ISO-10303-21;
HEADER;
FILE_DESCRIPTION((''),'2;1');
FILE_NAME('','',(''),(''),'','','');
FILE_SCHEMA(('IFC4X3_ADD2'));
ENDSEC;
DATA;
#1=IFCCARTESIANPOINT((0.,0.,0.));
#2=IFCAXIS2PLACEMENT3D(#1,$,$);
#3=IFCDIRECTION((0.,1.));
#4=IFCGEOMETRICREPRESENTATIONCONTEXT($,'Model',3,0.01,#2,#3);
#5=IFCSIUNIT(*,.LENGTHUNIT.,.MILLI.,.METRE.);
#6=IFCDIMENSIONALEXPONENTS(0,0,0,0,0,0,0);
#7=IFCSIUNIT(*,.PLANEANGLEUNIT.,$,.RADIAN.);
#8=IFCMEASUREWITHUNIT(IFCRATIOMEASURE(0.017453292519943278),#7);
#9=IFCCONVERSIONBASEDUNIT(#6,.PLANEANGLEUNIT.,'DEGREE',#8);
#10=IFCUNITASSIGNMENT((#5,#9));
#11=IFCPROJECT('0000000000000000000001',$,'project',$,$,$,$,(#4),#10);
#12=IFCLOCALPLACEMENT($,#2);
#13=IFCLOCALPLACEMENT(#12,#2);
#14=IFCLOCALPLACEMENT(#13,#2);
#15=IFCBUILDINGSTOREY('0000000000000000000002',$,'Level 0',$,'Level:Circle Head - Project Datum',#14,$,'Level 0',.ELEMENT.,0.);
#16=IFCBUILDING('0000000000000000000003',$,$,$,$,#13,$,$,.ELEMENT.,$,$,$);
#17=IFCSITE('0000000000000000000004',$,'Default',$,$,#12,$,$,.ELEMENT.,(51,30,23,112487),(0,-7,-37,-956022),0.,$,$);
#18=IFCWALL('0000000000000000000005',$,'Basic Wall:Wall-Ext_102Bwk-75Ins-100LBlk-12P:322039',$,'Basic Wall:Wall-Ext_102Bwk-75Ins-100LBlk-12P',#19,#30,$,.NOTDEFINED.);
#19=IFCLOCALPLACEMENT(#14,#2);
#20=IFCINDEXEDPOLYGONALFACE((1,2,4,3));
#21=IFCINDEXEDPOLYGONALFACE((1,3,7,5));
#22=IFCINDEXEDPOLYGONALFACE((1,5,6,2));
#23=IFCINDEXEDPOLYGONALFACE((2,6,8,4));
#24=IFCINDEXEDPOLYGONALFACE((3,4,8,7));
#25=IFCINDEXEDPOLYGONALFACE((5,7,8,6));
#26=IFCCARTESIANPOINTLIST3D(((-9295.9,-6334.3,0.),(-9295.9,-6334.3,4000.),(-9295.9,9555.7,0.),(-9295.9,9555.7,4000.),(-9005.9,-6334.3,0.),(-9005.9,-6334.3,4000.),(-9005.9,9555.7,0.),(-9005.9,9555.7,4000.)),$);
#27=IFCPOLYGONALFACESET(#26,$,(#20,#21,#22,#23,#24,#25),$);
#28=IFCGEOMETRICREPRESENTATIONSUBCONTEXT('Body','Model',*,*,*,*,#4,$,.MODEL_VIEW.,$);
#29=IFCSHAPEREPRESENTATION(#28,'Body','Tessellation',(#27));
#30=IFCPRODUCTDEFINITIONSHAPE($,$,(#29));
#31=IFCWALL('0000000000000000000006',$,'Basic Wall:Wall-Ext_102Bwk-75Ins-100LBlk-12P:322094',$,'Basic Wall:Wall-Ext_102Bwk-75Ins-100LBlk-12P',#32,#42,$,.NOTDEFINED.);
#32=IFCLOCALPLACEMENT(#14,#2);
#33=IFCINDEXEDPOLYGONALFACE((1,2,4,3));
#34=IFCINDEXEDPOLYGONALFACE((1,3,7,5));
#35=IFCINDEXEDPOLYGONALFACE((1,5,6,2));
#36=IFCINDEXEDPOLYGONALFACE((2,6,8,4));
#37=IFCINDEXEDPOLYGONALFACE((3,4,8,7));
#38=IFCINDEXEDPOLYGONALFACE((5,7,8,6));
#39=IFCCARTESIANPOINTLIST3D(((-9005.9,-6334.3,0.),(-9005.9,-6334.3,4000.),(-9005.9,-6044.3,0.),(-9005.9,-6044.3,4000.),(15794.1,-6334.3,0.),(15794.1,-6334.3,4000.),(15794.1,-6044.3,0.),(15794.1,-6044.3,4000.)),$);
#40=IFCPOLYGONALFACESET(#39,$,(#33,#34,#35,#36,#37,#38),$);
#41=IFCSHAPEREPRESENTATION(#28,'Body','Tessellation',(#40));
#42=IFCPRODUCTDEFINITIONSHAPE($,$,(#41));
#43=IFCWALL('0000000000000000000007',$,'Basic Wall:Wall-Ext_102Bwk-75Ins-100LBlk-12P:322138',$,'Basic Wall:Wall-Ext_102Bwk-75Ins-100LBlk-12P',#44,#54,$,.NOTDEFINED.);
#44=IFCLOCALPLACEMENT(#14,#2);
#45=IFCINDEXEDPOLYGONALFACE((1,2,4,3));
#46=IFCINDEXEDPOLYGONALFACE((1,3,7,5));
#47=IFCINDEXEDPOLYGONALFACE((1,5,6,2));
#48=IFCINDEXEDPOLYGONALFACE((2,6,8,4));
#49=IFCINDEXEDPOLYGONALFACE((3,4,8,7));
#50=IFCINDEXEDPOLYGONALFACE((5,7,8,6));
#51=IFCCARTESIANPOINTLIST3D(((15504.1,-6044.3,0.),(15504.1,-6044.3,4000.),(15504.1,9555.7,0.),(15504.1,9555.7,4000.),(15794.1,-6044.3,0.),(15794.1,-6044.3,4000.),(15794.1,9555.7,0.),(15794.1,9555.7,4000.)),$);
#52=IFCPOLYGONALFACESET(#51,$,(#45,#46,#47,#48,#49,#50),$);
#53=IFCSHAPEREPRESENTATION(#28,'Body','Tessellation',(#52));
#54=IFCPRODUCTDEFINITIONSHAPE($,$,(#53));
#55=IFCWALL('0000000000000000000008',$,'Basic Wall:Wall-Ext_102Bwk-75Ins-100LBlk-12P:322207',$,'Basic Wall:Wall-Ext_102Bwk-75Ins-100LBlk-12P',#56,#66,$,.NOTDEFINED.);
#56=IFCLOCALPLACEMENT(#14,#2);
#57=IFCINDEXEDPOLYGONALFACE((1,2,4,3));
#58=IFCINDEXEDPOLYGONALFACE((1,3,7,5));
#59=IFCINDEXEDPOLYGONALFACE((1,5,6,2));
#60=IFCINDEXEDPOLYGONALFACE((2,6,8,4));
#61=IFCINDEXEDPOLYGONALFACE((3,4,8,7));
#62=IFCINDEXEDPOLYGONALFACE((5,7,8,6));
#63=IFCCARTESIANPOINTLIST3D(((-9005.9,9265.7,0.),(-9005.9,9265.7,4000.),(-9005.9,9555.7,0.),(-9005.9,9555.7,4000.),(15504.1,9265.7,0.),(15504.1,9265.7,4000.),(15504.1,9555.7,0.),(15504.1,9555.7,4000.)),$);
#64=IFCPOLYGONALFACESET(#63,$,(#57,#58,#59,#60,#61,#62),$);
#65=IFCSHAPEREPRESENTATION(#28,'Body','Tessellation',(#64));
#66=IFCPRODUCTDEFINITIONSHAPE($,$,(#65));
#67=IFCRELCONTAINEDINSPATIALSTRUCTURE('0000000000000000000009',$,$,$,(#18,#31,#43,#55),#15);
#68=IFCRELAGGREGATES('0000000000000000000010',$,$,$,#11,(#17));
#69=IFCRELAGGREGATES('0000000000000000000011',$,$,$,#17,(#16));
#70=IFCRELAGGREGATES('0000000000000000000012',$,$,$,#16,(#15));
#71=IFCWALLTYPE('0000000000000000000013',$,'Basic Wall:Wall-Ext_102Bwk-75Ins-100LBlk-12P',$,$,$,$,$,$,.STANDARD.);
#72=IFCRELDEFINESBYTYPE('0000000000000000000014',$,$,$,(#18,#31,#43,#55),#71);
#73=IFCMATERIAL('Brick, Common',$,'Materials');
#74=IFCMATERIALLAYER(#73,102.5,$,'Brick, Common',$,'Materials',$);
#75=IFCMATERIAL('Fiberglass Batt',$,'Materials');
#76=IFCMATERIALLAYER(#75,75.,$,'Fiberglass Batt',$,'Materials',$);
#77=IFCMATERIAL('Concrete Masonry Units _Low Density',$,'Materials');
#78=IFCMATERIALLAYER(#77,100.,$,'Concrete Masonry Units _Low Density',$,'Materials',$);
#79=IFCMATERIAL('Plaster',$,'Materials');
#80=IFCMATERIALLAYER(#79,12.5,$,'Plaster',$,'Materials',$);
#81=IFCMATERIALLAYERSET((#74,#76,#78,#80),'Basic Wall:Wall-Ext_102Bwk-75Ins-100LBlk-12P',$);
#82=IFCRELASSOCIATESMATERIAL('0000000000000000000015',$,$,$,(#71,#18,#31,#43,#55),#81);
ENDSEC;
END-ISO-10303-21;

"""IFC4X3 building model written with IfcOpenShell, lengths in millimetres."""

from ifc_helpers import new_model, entity, si_unit, converted_unit, direction, frame, frame_2d, origin, place, context, subcontext, project, spatial, rectangle, extrude, clip, halfspace, material, layer, layer_set, type_object, element, save


model = new_model("IFC4X3")

# Units and contexts
model_context = context("Model", 3, precision=0.01, world=origin(), true_north=direction((0.0, 1.0)))
body_context = subcontext(model_context, "Body", "Model", "MODEL_VIEW")
ifc_project = project(units=[si_unit("LENGTHUNIT", "METRE", prefix="MILLI"), converted_unit("PLANEANGLEUNIT", "DEGREE", entity("IfcRatioMeasure", 0.017453292519943278), si_unit("PLANEANGLEUNIT", "RADIAN"), dimensions=[0, 0, 0, 0, 0, 0, 0])], contexts=[model_context])

# Site, building, storey
site_placement = place(None, origin())
site = spatial("IfcSite", under=ifc_project, at=site_placement, Name="Default", CompositionType="ELEMENT", RefLatitude=(51, 30, 23, 112487), RefLongitude=(0, -7, -37, -956022), RefElevation=0.0)
building_placement = place(site_placement, origin())
building = spatial("IfcBuilding", under=site, at=building_placement, CompositionType="ELEMENT")
storey_placement = place(building_placement, origin())
storey = spatial("IfcBuildingStorey", under=building, at=storey_placement, Name="Level 0", ObjectType="Level:Circle Head - Project Datum", LongName="Level 0", CompositionType="ELEMENT", Elevation=0.0)

# Walls
ifc_material_1 = material(Name="Brick, Common", Category="Materials")
ifc_layer_1 = layer(ifc_material_1, 102.5, Name="Brick, Common", Category="Materials")
ifc_material_2 = material(Name="Fiberglass Batt", Category="Materials")
ifc_layer_2 = layer(ifc_material_2, 75.0, Name="Fiberglass Batt", Category="Materials")
ifc_material_3 = material(Name="Concrete Masonry Units _Low Density", Category="Materials")
ifc_layer_3 = layer(ifc_material_3, 100.0, Name="Concrete Masonry Units _Low Density", Category="Materials")
ifc_material_4 = material(Name="Plaster", Category="Materials")
ifc_layer_4 = layer(ifc_material_4, 12.5, Name="Plaster", Category="Materials")
ifc_layer_set = layer_set([ifc_layer_1, ifc_layer_2, ifc_layer_3, ifc_layer_4], Name="Basic Wall:Wall-Ext_102Bwk-75Ins-100LBlk-12P")
wall_type = type_object("IfcWallType", Name="Basic Wall:Wall-Ext_102Bwk-75Ins-100LBlk-12P", PredefinedType="STANDARD", material=ifc_layer_set)
wall_1_placement = place(storey_placement, frame((-9150.9, 9555.7, 0.0), z_axis=(0.0, 0.0, 1.0), x_axis=(0.0, -1.0, 0.0)))
element("IfcWall", 1, at=wall_1_placement, inside=storey, type_object=wall_type, material=ifc_layer_set, Name="Basic Wall:Wall-Ext_102Bwk-75Ins-100LBlk-12P:322039", ObjectType="Basic Wall:Wall-Ext_102Bwk-75Ins-100LBlk-12P", PredefinedType="NOTDEFINED", context=body_context, shape_type="Clipping", body=[
    clip(extrude(rectangle(XDim=15890.0, YDim=290.0, at=frame_2d((7945.0, 0.0), x_axis=(-1.0, 0.0))), origin(), (0.0, 0.0, 1.0), 4000.0), halfspace(origin(), True)),
])
wall_2_placement = place(storey_placement, frame((-9005.9, -6189.3, 0.0)))
element("IfcWall", 2, at=wall_2_placement, inside=storey, type_object=wall_type, material=ifc_layer_set, Name="Basic Wall:Wall-Ext_102Bwk-75Ins-100LBlk-12P:322094", ObjectType="Basic Wall:Wall-Ext_102Bwk-75Ins-100LBlk-12P", PredefinedType="NOTDEFINED", context=body_context, shape_type="Clipping", body=[
    clip(extrude(rectangle(XDim=24800.0, YDim=290.0, at=frame_2d((12400.0, 0.0), x_axis=(-1.0, 0.0))), origin(), (0.0, 0.0, 1.0), 4000.0), halfspace(origin(), True)),
])
wall_3_placement = place(storey_placement, frame((15649.1, -6044.3, 0.0), z_axis=(0.0, 0.0, 1.0), x_axis=(0.0, 1.0, 0.0)))
element("IfcWall", 3, at=wall_3_placement, inside=storey, type_object=wall_type, material=ifc_layer_set, Name="Basic Wall:Wall-Ext_102Bwk-75Ins-100LBlk-12P:322138", ObjectType="Basic Wall:Wall-Ext_102Bwk-75Ins-100LBlk-12P", PredefinedType="NOTDEFINED", context=body_context, shape_type="Clipping", body=[
    clip(extrude(rectangle(XDim=15600.0, YDim=290.0, at=frame_2d((7800.0, 0.0), x_axis=(-1.0, 0.0))), origin(), (0.0, 0.0, 1.0), 4000.0), halfspace(origin(), True)),
])
wall_4_placement = place(storey_placement, frame((15504.1, 9410.7, 0.0), z_axis=(0.0, 0.0, 1.0), x_axis=(-1.0, 0.0, 0.0)))
element("IfcWall", 4, at=wall_4_placement, inside=storey, type_object=wall_type, material=ifc_layer_set, Name="Basic Wall:Wall-Ext_102Bwk-75Ins-100LBlk-12P:322207", ObjectType="Basic Wall:Wall-Ext_102Bwk-75Ins-100LBlk-12P", PredefinedType="NOTDEFINED", context=body_context, shape_type="Clipping", body=[
    clip(extrude(rectangle(XDim=24510.0, YDim=290.0, at=frame_2d((12255.0, 0.0), x_axis=(-1.0, 0.0))), origin(), (0.0, 0.0, 1.0), 4000.0), halfspace(origin(), True)),
])

save(model, "model.ifc")
